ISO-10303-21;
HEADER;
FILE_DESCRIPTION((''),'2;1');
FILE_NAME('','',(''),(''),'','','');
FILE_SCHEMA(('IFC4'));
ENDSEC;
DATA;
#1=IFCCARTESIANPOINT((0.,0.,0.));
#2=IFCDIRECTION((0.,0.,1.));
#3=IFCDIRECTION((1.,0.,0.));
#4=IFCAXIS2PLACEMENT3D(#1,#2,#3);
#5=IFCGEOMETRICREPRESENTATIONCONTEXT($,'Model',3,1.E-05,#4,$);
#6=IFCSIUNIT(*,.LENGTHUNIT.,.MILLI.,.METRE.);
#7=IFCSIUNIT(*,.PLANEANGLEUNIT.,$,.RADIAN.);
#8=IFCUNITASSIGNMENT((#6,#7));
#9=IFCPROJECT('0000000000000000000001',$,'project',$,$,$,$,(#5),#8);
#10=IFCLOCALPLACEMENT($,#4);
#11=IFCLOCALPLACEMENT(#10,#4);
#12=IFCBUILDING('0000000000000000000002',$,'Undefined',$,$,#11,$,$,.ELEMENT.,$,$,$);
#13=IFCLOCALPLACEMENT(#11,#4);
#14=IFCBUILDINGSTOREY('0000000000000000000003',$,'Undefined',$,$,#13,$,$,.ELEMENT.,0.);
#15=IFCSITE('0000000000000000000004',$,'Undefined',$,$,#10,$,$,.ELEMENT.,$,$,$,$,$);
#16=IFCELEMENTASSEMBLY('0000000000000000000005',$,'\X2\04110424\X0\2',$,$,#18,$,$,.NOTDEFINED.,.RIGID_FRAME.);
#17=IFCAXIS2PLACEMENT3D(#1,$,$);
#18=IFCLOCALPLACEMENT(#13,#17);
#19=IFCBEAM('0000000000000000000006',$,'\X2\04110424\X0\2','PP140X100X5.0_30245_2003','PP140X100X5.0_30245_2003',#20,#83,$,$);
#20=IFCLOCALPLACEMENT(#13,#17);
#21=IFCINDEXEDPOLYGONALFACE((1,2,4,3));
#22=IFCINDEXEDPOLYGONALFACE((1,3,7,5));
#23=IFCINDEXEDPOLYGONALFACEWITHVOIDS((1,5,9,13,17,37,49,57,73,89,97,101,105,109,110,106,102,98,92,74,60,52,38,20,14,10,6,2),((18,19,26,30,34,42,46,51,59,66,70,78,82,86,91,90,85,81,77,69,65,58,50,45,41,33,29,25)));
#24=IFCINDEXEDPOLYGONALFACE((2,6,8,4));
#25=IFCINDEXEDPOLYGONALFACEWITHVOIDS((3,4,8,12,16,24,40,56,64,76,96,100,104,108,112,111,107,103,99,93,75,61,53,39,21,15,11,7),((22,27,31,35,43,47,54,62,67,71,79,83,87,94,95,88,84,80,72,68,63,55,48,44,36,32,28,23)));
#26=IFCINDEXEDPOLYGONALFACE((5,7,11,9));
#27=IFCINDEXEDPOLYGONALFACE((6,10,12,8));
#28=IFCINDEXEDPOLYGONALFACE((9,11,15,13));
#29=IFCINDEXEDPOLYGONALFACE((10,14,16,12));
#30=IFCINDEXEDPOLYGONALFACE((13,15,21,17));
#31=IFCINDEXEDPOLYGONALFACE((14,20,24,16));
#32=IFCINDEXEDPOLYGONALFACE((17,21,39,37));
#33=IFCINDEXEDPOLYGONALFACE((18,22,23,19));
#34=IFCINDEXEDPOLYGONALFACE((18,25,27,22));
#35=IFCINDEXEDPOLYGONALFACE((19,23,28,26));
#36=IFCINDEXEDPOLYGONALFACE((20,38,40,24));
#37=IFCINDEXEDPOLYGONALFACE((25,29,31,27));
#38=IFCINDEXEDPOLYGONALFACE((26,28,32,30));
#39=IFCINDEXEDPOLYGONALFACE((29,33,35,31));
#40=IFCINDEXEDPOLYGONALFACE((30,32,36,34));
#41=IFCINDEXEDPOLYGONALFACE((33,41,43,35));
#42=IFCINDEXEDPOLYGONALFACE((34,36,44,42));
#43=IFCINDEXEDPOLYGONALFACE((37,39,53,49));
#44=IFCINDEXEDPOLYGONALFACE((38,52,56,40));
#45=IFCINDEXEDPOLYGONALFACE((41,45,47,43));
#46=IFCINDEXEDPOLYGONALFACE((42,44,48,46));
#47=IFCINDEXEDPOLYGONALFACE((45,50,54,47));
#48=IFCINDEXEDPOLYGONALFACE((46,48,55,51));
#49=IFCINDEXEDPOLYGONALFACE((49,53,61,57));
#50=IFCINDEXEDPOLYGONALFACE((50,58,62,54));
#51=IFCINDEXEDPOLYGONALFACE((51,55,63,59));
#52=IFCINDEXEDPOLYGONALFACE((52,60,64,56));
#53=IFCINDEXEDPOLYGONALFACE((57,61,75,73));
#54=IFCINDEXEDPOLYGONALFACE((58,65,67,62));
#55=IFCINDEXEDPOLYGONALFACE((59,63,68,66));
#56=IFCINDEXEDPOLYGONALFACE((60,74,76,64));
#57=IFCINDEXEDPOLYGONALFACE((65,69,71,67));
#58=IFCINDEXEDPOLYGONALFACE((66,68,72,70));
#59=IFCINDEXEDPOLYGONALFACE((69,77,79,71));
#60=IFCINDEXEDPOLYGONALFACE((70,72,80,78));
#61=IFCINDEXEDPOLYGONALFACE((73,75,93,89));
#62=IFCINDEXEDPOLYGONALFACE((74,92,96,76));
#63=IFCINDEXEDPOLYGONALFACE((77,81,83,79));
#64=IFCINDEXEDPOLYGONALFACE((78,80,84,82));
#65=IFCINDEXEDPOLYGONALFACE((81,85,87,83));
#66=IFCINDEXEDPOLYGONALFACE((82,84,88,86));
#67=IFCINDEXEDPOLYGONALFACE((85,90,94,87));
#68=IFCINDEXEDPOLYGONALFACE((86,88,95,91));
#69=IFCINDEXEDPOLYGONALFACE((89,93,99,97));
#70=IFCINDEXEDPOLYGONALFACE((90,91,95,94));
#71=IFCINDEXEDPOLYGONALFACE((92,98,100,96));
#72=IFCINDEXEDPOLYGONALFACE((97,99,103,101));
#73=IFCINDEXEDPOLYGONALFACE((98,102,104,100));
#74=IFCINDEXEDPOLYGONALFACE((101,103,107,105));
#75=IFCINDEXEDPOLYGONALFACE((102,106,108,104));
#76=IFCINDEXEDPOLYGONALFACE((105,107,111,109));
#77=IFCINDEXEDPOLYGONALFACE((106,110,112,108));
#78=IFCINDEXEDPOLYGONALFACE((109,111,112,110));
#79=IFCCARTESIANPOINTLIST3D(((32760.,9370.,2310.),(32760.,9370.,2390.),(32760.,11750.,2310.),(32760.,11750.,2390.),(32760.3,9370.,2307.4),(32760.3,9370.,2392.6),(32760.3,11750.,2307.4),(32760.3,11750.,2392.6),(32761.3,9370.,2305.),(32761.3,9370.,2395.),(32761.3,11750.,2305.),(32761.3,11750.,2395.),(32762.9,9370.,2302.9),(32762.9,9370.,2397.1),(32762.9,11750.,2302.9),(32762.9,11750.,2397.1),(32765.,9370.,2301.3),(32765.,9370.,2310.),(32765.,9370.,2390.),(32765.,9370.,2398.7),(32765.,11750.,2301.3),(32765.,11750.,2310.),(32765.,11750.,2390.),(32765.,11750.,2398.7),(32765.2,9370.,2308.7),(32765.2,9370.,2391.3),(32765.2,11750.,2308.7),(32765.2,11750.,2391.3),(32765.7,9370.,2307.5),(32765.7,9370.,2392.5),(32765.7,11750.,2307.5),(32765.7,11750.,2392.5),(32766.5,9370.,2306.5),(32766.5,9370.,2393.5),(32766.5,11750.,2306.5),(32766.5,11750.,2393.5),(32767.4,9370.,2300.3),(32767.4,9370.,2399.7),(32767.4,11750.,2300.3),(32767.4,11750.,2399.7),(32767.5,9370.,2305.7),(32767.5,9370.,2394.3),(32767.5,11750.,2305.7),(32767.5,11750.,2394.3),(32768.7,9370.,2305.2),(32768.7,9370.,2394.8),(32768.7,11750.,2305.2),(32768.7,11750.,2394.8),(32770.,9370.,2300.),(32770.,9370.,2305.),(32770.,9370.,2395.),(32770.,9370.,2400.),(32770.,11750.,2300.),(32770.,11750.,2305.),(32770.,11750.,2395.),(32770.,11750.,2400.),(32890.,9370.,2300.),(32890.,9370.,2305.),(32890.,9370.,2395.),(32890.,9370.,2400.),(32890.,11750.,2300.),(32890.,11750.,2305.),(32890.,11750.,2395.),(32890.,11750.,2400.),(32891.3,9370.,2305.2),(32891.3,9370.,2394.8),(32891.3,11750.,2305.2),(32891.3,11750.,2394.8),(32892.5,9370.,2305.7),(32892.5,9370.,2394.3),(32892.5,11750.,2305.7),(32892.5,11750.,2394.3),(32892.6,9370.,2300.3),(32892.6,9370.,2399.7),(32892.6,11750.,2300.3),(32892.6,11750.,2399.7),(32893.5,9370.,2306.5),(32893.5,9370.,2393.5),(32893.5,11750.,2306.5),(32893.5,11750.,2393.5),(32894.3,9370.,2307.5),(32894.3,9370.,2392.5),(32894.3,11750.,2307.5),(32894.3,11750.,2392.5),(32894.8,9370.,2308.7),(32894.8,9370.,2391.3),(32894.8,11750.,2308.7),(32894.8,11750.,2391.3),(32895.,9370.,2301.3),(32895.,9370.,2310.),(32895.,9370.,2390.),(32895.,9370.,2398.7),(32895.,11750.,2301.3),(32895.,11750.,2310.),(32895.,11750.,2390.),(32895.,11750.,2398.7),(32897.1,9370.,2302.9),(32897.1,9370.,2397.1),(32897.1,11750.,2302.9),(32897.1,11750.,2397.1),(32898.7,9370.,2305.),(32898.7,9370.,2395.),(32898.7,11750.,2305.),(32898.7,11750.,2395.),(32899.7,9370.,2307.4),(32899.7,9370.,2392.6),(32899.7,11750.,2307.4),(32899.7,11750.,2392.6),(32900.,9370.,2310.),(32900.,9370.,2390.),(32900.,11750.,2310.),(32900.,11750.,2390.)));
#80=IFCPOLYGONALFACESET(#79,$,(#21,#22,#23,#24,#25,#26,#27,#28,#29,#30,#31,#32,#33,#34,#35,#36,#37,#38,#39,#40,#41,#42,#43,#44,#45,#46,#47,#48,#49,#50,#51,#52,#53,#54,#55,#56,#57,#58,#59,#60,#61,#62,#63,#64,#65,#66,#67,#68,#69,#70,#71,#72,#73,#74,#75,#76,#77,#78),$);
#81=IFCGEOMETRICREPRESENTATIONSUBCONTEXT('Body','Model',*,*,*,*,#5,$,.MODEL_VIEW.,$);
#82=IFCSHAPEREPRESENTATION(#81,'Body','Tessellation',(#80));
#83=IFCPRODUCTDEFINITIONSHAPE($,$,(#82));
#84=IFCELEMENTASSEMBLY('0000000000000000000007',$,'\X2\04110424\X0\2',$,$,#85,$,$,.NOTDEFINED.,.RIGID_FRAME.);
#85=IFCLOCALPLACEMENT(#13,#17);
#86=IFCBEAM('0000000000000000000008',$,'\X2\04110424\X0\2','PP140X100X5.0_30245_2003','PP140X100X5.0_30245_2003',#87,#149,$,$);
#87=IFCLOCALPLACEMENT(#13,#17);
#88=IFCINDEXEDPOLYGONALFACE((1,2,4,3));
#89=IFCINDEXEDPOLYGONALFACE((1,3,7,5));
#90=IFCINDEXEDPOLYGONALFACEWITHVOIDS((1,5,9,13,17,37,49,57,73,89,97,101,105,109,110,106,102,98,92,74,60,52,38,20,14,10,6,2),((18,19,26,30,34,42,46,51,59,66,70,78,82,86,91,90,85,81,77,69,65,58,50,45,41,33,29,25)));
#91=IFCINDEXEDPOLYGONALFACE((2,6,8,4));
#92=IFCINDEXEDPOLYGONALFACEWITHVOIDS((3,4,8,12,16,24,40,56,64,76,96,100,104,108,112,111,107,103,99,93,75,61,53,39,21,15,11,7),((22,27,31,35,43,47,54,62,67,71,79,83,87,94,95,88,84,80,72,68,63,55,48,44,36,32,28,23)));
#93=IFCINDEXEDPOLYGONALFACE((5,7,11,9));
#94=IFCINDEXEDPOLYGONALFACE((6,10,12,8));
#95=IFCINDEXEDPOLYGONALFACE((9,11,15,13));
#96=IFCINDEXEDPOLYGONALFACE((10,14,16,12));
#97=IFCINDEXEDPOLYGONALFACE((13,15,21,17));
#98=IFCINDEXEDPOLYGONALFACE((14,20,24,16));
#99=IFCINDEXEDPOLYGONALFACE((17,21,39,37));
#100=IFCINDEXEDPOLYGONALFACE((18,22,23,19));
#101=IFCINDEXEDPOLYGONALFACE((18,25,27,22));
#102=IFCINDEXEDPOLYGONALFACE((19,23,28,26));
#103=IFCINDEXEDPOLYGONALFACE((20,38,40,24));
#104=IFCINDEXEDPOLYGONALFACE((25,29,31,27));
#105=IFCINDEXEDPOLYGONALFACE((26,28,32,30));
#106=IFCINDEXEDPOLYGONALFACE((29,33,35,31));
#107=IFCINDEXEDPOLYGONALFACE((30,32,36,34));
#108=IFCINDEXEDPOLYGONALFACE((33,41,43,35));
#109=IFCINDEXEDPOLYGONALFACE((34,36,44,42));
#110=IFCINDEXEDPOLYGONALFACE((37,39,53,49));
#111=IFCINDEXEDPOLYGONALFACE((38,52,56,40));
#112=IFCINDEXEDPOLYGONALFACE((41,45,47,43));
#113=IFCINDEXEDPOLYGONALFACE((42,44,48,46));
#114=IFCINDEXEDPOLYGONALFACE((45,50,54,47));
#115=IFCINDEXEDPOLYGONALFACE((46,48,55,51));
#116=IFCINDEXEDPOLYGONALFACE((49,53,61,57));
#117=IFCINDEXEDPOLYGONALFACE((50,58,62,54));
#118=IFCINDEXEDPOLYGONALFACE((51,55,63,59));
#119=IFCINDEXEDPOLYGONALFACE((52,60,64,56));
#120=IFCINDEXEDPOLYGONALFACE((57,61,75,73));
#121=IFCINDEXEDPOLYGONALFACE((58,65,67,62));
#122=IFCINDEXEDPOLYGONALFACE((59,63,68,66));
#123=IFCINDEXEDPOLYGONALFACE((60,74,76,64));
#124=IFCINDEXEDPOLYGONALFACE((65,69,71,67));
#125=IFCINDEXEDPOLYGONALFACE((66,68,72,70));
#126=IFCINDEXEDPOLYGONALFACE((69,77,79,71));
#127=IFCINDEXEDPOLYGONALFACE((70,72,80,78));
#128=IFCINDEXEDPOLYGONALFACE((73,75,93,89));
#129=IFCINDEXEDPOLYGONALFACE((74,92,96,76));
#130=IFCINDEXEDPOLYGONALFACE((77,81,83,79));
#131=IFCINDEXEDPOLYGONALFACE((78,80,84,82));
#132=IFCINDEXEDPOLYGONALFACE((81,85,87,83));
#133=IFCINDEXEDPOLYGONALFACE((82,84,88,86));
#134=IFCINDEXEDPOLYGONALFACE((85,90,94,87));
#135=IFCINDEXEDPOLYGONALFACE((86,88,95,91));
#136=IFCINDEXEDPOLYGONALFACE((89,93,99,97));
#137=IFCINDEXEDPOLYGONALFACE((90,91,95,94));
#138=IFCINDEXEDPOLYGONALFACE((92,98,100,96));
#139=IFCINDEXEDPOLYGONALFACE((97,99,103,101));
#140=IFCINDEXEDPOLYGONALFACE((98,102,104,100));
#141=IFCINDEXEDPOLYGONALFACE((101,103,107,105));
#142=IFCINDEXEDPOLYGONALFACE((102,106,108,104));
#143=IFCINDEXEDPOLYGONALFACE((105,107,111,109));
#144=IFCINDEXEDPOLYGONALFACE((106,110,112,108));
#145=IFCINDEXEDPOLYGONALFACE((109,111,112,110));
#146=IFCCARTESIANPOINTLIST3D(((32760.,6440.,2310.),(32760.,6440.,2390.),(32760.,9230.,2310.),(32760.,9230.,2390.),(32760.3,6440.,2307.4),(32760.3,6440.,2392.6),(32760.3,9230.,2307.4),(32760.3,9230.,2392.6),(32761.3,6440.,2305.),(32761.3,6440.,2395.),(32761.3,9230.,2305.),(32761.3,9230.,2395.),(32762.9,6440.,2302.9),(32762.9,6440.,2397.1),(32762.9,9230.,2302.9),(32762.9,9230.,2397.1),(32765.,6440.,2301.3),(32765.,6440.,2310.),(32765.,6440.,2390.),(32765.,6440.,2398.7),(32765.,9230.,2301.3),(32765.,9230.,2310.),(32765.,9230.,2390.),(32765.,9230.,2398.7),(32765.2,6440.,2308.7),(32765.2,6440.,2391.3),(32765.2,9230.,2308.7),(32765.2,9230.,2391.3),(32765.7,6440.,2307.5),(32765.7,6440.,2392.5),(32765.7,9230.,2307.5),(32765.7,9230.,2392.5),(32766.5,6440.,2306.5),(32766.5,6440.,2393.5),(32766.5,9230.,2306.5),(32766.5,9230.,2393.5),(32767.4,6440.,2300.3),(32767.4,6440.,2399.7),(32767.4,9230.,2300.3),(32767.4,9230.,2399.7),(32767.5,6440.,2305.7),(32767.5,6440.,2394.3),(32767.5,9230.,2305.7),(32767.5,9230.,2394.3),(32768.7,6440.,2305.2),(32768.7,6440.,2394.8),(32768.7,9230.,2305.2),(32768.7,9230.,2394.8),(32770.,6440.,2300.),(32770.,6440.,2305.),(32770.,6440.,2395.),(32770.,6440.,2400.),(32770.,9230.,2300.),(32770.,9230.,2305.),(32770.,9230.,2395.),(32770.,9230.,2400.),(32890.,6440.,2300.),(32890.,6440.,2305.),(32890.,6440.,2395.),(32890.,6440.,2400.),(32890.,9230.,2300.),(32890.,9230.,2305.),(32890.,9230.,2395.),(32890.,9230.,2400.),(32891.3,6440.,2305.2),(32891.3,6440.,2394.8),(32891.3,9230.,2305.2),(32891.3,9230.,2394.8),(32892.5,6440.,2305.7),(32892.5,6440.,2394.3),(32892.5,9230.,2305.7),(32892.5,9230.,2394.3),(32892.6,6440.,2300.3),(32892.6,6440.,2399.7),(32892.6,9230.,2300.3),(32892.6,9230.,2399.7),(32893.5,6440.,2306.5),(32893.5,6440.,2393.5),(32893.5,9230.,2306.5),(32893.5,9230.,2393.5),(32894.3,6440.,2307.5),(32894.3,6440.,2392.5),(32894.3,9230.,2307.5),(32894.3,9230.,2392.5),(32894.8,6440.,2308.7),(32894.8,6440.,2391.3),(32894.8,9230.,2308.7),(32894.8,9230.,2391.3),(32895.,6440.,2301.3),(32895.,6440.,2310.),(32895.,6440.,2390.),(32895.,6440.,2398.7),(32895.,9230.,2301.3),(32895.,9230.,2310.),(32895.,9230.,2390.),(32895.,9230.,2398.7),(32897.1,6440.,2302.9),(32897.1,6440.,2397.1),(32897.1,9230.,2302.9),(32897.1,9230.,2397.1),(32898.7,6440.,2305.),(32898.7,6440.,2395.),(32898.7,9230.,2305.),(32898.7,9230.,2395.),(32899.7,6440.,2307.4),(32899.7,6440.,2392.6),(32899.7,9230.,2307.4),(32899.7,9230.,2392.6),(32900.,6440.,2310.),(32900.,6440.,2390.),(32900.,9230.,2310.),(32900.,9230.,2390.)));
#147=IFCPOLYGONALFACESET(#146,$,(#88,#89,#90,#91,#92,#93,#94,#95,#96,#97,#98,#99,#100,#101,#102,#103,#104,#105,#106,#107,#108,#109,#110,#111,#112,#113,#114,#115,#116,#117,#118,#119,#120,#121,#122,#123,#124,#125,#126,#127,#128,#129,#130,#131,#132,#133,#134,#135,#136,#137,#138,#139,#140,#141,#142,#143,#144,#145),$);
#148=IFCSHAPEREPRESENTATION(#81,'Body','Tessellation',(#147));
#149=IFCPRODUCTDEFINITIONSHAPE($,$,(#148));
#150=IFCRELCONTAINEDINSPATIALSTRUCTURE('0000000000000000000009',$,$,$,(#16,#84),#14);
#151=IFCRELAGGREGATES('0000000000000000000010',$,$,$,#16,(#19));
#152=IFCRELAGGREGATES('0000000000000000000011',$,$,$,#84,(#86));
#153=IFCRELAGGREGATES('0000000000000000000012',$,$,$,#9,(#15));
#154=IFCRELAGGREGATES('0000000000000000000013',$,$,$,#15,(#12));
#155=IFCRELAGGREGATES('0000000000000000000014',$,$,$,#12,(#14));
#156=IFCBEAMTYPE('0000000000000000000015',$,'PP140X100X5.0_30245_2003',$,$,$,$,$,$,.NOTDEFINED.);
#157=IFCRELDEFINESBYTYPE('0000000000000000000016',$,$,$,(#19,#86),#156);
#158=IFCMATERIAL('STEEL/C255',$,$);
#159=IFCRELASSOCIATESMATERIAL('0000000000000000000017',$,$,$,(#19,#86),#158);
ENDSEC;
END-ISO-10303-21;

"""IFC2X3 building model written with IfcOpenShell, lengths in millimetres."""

from ifc_helpers import new_model, si_unit, frame, origin_with_axes, origin_2d_with_axis, place, context, subcontext, project, spatial, hollow_rectangle, extrude, material, type_object, element, aggregate, save


model = new_model("IFC2X3")

# Units and contexts
model_context = context("Model", 3, precision=1e-05, world=origin_with_axes())
body_context = subcontext(model_context, "Body", "Model", "MODEL_VIEW")
ifc_project = project(units=[si_unit("LENGTHUNIT", "METRE", prefix="MILLI"), si_unit("PLANEANGLEUNIT", "RADIAN")], contexts=[model_context])

# Site, building, storey
site_placement = place(None, origin_with_axes())
site = spatial("IfcSite", under=ifc_project, at=site_placement, Name="Undefined", CompositionType="ELEMENT")
building_placement = place(site_placement, origin_with_axes())
building = spatial("IfcBuilding", under=site, at=building_placement, Name="Undefined", CompositionType="ELEMENT")
storey_placement = place(building_placement, origin_with_axes())
storey = spatial("IfcBuildingStorey", under=building, at=storey_placement, Name="Undefined", CompositionType="ELEMENT", Elevation=0.0)

# Shared definitions
ifc_material_1 = material(Name="STEEL/C255")

# Element assemblies, beams
beam_type_1 = type_object("IfcBeamType", Name="PP140X100X5.0_30245_2003", PredefinedType="NOTDEFINED")
assembly_1_placement = place(storey_placement, origin_with_axes())
assembly_1 = element("IfcElementAssembly", 1, at=assembly_1_placement, inside=storey, Name="БФ2", AssemblyPlace="NOTDEFINED", PredefinedType="RIGID_FRAME")
beam_1_placement = place(assembly_1_placement, frame((32830.0, 9370.0, 2350.0), z_axis=(1.0, 0.0, 0.0), x_axis=(0.0, 1.0, 0.0)))
beam_1 = element("IfcBeam", 2, at=beam_1_placement, type_object=beam_type_1, material=ifc_material_1, Name="БФ2", Description="PP140X100X5.0_30245_2003", ObjectType="PP140X100X5.0_30245_2003", context=body_context, shape_type="SweptSolid", body=[
    extrude(hollow_rectangle(XDim=100.0, YDim=140.0, WallThickness=5.0, InnerFilletRadius=5.0, OuterFilletRadius=10.0, at=origin_2d_with_axis()), frame((2380.0, 0.0, 0.0), z_axis=(-1.0, 0.0, 0.0), x_axis=(0.0, -1.0, 0.0)), (0.0, 0.0, 1.0), 2380.0),
])
aggregate(assembly_1, [beam_1])
assembly_2_placement = place(storey_placement, origin_with_axes())
assembly_2 = element("IfcElementAssembly", 3, at=assembly_2_placement, inside=storey, Name="БФ2", AssemblyPlace="NOTDEFINED", PredefinedType="RIGID_FRAME")
beam_2_placement = place(assembly_2_placement, frame((32830.0, 6440.0, 2350.0), z_axis=(1.0, 0.0, 0.0), x_axis=(0.0, 1.0, 0.0)))
beam_2 = element("IfcBeam", 4, at=beam_2_placement, type_object=beam_type_1, material=ifc_material_1, Name="БФ2", Description="PP140X100X5.0_30245_2003", ObjectType="PP140X100X5.0_30245_2003", context=body_context, shape_type="SweptSolid", body=[
    extrude(hollow_rectangle(XDim=100.0, YDim=140.0, WallThickness=5.0, InnerFilletRadius=5.0, OuterFilletRadius=10.0, at=origin_2d_with_axis()), frame((2790.0, 0.0, 0.0), z_axis=(-1.0, 0.0, 0.0), x_axis=(0.0, -1.0, 0.0)), (0.0, 0.0, 1.0), 2790.0),
])
aggregate(assembly_2, [beam_2])

save(model, "model.ifc")
